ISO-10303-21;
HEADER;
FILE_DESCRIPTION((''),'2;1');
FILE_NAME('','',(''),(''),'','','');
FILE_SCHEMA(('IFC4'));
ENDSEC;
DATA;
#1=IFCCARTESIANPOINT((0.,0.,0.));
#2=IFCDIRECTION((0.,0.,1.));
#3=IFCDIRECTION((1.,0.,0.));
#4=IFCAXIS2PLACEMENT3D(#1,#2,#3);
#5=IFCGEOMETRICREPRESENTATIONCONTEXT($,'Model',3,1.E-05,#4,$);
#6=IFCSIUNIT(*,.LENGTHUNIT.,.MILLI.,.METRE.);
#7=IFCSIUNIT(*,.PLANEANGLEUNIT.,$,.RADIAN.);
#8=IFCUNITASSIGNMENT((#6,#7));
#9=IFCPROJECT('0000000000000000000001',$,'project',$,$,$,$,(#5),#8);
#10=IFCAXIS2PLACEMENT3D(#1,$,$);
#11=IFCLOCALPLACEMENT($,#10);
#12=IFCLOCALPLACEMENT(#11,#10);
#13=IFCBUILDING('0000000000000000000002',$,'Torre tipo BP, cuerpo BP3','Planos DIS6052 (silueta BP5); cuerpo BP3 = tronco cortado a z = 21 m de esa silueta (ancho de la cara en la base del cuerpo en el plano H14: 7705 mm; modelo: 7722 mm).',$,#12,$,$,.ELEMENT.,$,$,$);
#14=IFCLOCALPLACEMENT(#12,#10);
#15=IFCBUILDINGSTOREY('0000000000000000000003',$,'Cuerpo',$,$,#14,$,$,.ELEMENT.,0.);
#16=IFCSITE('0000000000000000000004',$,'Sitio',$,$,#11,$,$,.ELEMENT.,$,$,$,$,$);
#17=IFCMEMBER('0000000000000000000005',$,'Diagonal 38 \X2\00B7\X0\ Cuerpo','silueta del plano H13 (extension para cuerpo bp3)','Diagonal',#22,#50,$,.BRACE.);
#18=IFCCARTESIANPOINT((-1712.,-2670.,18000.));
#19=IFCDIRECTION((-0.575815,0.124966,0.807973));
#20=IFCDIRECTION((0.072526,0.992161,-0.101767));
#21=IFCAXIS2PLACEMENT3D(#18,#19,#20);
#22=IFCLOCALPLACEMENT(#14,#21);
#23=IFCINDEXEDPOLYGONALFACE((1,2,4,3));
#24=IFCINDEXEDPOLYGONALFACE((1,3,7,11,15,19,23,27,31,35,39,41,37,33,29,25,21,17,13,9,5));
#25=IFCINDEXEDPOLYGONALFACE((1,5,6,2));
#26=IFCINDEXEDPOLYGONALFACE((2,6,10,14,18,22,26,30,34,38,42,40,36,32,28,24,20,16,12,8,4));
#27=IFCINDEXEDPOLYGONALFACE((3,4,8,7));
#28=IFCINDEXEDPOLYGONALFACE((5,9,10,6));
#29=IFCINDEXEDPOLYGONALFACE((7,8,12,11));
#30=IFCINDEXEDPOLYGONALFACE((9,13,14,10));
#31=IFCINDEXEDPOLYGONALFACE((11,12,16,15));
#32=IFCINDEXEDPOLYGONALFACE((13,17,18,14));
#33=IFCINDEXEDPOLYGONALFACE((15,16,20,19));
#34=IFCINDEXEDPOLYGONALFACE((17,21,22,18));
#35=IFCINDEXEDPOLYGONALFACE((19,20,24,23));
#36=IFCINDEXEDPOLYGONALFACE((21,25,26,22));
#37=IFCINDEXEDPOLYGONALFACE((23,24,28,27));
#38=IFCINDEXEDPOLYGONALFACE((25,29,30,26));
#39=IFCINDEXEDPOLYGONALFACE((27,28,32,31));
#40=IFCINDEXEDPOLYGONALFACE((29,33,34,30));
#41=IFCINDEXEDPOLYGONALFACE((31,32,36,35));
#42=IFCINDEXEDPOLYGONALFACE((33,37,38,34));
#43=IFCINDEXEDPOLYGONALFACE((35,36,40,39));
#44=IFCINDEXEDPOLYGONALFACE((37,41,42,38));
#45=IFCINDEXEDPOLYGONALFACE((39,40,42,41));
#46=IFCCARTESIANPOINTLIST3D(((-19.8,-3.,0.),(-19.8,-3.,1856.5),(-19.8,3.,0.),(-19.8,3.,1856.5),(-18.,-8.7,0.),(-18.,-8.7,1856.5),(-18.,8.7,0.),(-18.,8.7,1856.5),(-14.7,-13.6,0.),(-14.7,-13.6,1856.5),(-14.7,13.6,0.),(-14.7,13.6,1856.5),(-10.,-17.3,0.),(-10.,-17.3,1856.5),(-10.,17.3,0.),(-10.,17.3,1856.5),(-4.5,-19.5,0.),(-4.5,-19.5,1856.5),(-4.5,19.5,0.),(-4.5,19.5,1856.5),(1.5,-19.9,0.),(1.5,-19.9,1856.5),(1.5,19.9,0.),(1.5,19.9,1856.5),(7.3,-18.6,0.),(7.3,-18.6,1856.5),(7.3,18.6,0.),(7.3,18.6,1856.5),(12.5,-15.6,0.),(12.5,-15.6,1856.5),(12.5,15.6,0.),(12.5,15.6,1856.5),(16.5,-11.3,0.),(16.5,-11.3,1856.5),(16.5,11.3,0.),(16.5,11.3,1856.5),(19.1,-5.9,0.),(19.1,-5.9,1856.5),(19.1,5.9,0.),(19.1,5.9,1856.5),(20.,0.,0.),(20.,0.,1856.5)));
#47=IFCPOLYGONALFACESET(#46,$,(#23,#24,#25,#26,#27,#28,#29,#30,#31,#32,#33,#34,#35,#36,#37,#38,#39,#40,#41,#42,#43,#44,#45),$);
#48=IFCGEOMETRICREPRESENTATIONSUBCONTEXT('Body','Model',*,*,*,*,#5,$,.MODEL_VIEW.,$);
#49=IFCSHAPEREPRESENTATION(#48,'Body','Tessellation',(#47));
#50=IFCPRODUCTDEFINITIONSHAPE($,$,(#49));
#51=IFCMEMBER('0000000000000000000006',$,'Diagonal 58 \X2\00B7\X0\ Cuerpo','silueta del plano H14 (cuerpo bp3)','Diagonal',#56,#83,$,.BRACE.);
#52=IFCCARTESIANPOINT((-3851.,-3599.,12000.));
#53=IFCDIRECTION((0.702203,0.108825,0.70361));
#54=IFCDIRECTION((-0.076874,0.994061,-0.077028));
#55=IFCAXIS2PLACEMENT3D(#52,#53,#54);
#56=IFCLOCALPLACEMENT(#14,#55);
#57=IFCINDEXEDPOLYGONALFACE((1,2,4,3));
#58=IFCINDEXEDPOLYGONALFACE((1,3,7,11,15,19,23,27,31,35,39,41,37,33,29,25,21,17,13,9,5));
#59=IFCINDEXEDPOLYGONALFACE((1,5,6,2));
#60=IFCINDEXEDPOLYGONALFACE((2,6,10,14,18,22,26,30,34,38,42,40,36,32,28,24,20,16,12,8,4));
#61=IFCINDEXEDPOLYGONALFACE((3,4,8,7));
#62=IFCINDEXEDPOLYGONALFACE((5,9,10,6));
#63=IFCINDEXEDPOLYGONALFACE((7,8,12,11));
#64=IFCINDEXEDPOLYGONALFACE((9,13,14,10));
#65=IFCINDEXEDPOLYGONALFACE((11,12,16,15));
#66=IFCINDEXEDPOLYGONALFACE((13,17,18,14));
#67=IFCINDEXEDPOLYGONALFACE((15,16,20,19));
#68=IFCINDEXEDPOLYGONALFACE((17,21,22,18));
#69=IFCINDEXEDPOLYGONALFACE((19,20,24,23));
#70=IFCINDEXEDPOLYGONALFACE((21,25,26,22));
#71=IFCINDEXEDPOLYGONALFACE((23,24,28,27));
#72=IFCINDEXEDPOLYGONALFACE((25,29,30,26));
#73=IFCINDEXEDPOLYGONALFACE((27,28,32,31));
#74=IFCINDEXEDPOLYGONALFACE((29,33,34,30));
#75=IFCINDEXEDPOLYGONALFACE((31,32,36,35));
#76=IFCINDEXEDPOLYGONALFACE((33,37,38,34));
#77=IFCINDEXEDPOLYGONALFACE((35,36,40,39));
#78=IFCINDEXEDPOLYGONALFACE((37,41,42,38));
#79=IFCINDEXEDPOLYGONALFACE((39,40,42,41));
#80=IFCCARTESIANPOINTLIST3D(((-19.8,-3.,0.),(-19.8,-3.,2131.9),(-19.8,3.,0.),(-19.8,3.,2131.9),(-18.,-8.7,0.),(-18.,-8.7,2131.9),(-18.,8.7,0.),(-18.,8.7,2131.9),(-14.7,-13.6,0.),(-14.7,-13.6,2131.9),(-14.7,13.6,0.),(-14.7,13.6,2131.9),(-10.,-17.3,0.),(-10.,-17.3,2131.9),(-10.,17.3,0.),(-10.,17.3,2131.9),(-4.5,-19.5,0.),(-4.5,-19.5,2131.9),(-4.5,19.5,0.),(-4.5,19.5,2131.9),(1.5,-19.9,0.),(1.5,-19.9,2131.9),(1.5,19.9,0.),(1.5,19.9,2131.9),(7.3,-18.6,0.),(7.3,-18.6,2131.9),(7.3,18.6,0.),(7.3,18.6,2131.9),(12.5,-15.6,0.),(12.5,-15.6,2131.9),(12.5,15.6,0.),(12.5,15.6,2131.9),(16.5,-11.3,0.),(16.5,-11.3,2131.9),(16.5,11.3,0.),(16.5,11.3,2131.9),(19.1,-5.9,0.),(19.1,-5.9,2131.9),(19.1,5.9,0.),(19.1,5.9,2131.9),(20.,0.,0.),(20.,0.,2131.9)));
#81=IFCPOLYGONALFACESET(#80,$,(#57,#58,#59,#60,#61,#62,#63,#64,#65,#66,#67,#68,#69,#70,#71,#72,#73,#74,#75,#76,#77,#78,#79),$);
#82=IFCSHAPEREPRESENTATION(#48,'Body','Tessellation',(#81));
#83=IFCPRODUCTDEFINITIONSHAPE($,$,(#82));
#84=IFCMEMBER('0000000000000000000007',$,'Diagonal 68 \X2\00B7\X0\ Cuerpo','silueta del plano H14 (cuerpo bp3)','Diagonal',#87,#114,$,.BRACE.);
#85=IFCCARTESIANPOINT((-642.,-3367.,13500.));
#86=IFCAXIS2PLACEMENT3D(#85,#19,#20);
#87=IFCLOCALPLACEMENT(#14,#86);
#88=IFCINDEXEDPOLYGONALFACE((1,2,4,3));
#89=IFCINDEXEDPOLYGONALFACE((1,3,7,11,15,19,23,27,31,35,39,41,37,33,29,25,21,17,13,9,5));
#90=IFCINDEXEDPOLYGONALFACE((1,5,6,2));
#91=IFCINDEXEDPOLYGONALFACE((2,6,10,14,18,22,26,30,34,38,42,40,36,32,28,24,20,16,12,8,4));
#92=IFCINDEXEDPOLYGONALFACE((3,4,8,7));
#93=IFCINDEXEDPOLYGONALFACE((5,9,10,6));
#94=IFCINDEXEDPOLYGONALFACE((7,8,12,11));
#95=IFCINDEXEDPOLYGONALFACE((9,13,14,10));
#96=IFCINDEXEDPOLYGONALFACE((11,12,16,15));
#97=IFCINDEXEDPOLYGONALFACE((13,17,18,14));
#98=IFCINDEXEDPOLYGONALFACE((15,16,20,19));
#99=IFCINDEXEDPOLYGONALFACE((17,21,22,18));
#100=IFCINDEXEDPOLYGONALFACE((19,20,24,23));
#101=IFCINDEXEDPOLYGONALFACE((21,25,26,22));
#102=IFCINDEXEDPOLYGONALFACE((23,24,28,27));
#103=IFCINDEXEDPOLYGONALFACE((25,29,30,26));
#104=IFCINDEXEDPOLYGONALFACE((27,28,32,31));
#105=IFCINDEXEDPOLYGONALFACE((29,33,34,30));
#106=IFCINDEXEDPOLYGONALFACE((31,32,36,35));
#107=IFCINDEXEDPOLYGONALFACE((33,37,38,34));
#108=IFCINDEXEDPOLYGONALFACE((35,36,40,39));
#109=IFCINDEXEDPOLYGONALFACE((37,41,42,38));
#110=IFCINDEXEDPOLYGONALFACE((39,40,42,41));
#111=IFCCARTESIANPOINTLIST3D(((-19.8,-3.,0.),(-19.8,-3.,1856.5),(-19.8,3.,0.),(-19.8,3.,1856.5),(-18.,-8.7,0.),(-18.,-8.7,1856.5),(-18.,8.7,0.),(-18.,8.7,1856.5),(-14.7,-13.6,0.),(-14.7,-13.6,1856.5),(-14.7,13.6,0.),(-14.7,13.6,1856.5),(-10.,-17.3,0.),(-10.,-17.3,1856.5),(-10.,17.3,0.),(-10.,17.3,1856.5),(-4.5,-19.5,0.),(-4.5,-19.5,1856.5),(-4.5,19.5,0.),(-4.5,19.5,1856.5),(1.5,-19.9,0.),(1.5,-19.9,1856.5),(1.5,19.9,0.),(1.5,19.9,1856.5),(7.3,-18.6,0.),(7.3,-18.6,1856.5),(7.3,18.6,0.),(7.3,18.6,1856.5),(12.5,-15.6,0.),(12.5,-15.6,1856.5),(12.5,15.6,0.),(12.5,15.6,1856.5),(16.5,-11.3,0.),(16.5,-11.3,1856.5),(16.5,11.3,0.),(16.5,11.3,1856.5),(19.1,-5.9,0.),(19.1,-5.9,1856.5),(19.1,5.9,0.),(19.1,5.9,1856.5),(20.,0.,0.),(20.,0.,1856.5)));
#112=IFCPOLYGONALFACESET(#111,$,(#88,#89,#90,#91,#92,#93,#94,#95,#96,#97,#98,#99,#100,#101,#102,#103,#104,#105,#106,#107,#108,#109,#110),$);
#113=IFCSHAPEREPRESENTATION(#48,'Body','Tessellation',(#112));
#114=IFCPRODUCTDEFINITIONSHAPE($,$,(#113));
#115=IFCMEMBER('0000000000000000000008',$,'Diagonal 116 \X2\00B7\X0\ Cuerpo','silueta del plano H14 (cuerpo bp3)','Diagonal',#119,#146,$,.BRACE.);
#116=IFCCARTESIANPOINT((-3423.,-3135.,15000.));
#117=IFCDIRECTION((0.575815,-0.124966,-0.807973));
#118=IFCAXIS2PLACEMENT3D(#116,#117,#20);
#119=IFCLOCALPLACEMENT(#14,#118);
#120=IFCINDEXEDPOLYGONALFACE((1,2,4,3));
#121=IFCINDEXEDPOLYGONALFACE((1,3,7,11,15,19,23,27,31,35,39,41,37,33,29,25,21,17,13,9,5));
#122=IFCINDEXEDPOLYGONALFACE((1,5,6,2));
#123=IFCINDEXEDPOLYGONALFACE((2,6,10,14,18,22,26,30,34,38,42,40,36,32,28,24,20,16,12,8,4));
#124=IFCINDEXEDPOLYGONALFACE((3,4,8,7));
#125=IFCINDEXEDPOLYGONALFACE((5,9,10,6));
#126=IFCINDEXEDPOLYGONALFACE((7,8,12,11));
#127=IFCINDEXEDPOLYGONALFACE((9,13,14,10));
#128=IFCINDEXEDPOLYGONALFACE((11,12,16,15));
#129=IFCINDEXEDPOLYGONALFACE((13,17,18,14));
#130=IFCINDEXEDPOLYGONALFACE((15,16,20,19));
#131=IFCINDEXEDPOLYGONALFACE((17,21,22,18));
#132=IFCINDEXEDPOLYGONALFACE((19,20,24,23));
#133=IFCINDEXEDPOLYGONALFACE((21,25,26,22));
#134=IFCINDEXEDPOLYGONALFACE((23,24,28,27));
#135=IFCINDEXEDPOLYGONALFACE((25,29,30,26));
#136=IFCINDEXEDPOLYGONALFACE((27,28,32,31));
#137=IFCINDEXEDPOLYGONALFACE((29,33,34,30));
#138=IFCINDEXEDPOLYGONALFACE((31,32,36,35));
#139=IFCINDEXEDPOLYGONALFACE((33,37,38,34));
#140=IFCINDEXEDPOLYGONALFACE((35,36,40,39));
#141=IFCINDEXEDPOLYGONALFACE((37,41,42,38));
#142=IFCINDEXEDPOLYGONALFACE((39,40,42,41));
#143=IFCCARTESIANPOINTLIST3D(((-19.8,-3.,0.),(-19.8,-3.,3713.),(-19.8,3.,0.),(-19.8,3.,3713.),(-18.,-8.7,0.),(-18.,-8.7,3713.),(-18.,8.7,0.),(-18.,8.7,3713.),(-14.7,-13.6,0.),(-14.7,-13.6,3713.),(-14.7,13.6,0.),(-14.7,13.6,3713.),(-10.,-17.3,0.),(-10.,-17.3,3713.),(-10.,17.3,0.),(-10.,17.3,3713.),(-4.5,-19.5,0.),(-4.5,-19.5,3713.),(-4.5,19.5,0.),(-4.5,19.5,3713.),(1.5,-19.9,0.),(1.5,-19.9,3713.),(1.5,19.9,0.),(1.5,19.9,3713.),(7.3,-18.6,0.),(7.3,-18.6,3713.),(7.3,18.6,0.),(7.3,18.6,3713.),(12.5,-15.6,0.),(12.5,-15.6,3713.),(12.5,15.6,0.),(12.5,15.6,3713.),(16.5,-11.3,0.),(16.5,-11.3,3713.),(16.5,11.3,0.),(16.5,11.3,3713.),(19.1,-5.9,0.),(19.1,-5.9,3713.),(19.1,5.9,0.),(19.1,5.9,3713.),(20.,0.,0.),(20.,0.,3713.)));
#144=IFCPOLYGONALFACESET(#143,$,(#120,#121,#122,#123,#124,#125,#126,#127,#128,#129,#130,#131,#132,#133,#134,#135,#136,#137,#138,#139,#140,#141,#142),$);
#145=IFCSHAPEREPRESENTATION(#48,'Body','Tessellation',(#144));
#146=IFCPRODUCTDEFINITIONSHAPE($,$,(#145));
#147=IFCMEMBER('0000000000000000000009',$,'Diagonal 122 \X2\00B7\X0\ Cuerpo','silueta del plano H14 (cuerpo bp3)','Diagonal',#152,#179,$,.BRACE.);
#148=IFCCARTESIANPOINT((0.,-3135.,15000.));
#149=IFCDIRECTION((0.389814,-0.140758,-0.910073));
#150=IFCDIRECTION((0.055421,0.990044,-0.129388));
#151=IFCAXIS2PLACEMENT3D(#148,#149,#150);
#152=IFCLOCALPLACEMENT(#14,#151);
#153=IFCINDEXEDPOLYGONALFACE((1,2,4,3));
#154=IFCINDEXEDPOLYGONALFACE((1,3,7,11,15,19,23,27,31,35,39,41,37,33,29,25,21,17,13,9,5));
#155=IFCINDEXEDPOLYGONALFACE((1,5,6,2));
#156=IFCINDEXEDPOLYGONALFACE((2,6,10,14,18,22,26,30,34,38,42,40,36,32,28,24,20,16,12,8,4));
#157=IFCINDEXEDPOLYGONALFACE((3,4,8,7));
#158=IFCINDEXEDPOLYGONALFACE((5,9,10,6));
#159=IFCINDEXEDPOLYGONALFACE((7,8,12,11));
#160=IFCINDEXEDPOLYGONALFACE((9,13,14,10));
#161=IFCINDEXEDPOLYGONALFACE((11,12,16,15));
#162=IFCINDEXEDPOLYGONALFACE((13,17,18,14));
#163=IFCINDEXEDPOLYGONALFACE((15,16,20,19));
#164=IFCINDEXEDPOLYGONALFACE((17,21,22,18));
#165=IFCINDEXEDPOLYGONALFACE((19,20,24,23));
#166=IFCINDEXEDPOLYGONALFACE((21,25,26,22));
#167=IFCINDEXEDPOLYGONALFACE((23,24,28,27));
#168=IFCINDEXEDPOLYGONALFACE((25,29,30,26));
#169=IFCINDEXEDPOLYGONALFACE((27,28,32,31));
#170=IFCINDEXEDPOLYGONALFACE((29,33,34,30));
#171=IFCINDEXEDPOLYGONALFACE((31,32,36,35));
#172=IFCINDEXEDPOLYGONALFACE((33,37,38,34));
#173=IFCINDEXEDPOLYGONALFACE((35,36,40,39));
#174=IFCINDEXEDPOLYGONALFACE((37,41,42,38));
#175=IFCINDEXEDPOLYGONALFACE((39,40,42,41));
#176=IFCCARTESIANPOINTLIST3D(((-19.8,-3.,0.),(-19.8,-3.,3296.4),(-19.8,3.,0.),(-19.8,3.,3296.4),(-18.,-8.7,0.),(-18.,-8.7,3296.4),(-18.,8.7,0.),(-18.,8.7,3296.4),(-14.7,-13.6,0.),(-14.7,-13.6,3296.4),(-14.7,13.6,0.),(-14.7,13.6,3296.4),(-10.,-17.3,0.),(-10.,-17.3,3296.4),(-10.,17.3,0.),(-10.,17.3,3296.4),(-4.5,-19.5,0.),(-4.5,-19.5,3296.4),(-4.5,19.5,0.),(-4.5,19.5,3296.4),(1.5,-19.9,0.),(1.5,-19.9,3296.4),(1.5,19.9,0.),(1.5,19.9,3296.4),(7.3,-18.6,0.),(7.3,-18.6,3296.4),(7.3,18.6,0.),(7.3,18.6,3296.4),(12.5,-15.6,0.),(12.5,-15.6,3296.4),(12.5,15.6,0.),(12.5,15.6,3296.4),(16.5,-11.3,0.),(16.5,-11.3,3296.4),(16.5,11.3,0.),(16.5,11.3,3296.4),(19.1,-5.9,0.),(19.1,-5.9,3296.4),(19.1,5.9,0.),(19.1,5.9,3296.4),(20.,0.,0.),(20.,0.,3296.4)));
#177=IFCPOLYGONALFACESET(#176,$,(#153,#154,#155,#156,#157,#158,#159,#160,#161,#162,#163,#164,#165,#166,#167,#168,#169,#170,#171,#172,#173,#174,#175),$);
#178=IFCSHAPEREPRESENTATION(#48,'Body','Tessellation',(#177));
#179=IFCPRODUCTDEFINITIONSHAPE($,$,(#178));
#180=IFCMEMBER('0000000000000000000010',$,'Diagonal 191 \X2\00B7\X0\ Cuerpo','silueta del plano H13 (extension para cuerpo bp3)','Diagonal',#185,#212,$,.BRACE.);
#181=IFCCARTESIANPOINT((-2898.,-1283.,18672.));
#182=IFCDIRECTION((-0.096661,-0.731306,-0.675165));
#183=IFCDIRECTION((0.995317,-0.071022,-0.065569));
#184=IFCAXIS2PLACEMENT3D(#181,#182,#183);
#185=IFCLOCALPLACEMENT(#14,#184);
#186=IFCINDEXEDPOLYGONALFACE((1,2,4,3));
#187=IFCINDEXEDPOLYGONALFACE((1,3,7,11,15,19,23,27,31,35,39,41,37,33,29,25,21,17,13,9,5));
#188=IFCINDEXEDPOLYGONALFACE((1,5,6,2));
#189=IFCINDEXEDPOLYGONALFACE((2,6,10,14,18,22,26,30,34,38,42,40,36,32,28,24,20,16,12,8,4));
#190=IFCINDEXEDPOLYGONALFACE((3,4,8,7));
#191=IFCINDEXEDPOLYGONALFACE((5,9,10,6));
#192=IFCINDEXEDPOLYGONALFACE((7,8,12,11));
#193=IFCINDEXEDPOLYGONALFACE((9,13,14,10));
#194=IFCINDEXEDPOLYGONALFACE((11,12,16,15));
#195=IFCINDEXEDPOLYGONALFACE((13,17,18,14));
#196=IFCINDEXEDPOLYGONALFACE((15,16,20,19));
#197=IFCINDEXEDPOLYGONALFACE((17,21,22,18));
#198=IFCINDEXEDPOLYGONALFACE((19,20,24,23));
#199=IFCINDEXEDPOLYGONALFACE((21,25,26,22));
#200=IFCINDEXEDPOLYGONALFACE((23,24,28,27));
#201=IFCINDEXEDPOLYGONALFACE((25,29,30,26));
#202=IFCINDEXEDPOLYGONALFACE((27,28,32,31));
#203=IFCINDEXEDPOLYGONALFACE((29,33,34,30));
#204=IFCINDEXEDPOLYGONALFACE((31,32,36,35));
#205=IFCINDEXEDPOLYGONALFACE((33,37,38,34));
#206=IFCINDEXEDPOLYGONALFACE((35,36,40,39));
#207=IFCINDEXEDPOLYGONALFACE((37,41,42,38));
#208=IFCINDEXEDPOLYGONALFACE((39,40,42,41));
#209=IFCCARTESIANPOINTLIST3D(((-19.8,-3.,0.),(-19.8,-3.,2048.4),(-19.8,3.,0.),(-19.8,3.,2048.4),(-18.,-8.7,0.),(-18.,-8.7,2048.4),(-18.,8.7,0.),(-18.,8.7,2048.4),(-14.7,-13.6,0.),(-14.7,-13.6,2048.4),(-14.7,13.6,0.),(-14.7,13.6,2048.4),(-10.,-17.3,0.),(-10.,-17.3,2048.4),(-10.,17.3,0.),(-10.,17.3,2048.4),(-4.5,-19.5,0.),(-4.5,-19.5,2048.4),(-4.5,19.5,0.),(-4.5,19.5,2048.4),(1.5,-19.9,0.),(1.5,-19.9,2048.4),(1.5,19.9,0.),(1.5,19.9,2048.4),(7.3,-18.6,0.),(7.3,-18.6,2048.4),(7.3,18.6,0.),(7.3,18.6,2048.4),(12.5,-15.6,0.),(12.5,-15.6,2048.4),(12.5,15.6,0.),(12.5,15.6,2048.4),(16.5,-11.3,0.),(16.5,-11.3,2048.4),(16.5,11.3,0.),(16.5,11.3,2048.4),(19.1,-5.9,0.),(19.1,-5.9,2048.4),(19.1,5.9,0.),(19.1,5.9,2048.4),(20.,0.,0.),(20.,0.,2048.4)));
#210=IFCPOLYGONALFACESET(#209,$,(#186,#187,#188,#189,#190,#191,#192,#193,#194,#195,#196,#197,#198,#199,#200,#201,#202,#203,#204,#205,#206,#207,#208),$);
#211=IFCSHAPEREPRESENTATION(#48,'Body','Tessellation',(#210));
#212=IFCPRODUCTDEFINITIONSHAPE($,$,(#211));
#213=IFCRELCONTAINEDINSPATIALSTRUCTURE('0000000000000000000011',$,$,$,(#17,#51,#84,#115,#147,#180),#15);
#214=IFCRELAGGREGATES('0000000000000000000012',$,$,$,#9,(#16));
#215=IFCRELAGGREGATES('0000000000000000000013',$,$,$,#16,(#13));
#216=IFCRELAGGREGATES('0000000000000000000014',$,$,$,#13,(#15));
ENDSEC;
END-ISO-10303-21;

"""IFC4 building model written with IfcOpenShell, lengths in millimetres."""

from ifc_helpers import new_model, si_unit, frame, origin, origin_with_axes, place, context, subcontext, project, spatial, circle, extrude, element, save


model = new_model("IFC4")

# Units and contexts
model_context = context("Model", 3, precision=1e-05, world=origin_with_axes())
body_context = subcontext(model_context, "Body", "Model", "MODEL_VIEW")
ifc_project = project(units=[si_unit("LENGTHUNIT", "METRE", prefix="MILLI"), si_unit("PLANEANGLEUNIT", "RADIAN")], contexts=[model_context])

# Site, building, storey
site_placement = place(None, origin())
site = spatial("IfcSite", under=ifc_project, at=site_placement, Name="Sitio", CompositionType="ELEMENT")
building_placement = place(site_placement, origin())
building = spatial("IfcBuilding", under=site, at=building_placement, Name="Torre tipo BP, cuerpo BP3", Description="Planos DIS6052 (silueta BP5); cuerpo BP3 = tronco cortado a z = 21 m de esa silueta (ancho de la cara en la base del cuerpo en el plano H14: 7705 mm; modelo: 7722 mm).", CompositionType="ELEMENT")
storey_placement = place(building_placement, origin())
storey = spatial("IfcBuildingStorey", under=building, at=storey_placement, Name="Cuerpo", CompositionType="ELEMENT", Elevation=0.0)

# Members
member_1_placement = place(storey_placement, frame((-1712.0, -2670.0, 18000.0), z_axis=(-0.575815, 0.124966, 0.807973), x_axis=(0.072526, 0.992161, -0.101767)))
element("IfcMember", 1, at=member_1_placement, inside=storey, Name="Diagonal 38 · Cuerpo", Description="silueta del plano H13 (extension para cuerpo bp3)", ObjectType="Diagonal", PredefinedType="BRACE", context=body_context, shape_type="SweptSolid", body=[
    extrude(circle(Radius=20.0), None, (0.0, 0.0, 1.0), 1856.5),
])
member_2_placement = place(storey_placement, frame((-3851.0, -3599.0, 12000.0), z_axis=(0.702203, 0.108825, 0.70361), x_axis=(-0.076874, 0.994061, -0.077028)))
element("IfcMember", 2, at=member_2_placement, inside=storey, Name="Diagonal 58 · Cuerpo", Description="silueta del plano H14 (cuerpo bp3)", ObjectType="Diagonal", PredefinedType="BRACE", context=body_context, shape_type="SweptSolid", body=[
    extrude(circle(Radius=20.0), None, (0.0, 0.0, 1.0), 2131.9),
])
member_3_placement = place(storey_placement, frame((-642.0, -3367.0, 13500.0), z_axis=(-0.575815, 0.124966, 0.807973), x_axis=(0.072526, 0.992161, -0.101767)))
element("IfcMember", 3, at=member_3_placement, inside=storey, Name="Diagonal 68 · Cuerpo", Description="silueta del plano H14 (cuerpo bp3)", ObjectType="Diagonal", PredefinedType="BRACE", context=body_context, shape_type="SweptSolid", body=[
    extrude(circle(Radius=20.0), None, (0.0, 0.0, 1.0), 1856.5),
])
member_4_placement = place(storey_placement, frame((-3423.0, -3135.0, 15000.0), z_axis=(0.575815, -0.124966, -0.807973), x_axis=(0.072526, 0.992161, -0.101767)))
element("IfcMember", 4, at=member_4_placement, inside=storey, Name="Diagonal 116 · Cuerpo", Description="silueta del plano H14 (cuerpo bp3)", ObjectType="Diagonal", PredefinedType="BRACE", context=body_context, shape_type="SweptSolid", body=[
    extrude(circle(Radius=20.0), None, (0.0, 0.0, 1.0), 3713.0),
])
member_5_placement = place(storey_placement, frame((0.0, -3135.0, 15000.0), z_axis=(0.389814, -0.140758, -0.910073), x_axis=(0.055421, 0.990044, -0.129388)))
element("IfcMember", 5, at=member_5_placement, inside=storey, Name="Diagonal 122 · Cuerpo", Description="silueta del plano H14 (cuerpo bp3)", ObjectType="Diagonal", PredefinedType="BRACE", context=body_context, shape_type="SweptSolid", body=[
    extrude(circle(Radius=20.0), None, (0.0, 0.0, 1.0), 3296.4),
])
member_6_placement = place(storey_placement, frame((-2898.0, -1283.0, 18672.0), z_axis=(-0.096661, -0.731306, -0.675165), x_axis=(0.995317, -0.071022, -0.065569)))
element("IfcMember", 6, at=member_6_placement, inside=storey, Name="Diagonal 191 · Cuerpo", Description="silueta del plano H13 (extension para cuerpo bp3)", ObjectType="Diagonal", PredefinedType="BRACE", context=body_context, shape_type="SweptSolid", body=[
    extrude(circle(Radius=20.0), None, (0.0, 0.0, 1.0), 2048.4),
])

save(model, "model.ifc")
